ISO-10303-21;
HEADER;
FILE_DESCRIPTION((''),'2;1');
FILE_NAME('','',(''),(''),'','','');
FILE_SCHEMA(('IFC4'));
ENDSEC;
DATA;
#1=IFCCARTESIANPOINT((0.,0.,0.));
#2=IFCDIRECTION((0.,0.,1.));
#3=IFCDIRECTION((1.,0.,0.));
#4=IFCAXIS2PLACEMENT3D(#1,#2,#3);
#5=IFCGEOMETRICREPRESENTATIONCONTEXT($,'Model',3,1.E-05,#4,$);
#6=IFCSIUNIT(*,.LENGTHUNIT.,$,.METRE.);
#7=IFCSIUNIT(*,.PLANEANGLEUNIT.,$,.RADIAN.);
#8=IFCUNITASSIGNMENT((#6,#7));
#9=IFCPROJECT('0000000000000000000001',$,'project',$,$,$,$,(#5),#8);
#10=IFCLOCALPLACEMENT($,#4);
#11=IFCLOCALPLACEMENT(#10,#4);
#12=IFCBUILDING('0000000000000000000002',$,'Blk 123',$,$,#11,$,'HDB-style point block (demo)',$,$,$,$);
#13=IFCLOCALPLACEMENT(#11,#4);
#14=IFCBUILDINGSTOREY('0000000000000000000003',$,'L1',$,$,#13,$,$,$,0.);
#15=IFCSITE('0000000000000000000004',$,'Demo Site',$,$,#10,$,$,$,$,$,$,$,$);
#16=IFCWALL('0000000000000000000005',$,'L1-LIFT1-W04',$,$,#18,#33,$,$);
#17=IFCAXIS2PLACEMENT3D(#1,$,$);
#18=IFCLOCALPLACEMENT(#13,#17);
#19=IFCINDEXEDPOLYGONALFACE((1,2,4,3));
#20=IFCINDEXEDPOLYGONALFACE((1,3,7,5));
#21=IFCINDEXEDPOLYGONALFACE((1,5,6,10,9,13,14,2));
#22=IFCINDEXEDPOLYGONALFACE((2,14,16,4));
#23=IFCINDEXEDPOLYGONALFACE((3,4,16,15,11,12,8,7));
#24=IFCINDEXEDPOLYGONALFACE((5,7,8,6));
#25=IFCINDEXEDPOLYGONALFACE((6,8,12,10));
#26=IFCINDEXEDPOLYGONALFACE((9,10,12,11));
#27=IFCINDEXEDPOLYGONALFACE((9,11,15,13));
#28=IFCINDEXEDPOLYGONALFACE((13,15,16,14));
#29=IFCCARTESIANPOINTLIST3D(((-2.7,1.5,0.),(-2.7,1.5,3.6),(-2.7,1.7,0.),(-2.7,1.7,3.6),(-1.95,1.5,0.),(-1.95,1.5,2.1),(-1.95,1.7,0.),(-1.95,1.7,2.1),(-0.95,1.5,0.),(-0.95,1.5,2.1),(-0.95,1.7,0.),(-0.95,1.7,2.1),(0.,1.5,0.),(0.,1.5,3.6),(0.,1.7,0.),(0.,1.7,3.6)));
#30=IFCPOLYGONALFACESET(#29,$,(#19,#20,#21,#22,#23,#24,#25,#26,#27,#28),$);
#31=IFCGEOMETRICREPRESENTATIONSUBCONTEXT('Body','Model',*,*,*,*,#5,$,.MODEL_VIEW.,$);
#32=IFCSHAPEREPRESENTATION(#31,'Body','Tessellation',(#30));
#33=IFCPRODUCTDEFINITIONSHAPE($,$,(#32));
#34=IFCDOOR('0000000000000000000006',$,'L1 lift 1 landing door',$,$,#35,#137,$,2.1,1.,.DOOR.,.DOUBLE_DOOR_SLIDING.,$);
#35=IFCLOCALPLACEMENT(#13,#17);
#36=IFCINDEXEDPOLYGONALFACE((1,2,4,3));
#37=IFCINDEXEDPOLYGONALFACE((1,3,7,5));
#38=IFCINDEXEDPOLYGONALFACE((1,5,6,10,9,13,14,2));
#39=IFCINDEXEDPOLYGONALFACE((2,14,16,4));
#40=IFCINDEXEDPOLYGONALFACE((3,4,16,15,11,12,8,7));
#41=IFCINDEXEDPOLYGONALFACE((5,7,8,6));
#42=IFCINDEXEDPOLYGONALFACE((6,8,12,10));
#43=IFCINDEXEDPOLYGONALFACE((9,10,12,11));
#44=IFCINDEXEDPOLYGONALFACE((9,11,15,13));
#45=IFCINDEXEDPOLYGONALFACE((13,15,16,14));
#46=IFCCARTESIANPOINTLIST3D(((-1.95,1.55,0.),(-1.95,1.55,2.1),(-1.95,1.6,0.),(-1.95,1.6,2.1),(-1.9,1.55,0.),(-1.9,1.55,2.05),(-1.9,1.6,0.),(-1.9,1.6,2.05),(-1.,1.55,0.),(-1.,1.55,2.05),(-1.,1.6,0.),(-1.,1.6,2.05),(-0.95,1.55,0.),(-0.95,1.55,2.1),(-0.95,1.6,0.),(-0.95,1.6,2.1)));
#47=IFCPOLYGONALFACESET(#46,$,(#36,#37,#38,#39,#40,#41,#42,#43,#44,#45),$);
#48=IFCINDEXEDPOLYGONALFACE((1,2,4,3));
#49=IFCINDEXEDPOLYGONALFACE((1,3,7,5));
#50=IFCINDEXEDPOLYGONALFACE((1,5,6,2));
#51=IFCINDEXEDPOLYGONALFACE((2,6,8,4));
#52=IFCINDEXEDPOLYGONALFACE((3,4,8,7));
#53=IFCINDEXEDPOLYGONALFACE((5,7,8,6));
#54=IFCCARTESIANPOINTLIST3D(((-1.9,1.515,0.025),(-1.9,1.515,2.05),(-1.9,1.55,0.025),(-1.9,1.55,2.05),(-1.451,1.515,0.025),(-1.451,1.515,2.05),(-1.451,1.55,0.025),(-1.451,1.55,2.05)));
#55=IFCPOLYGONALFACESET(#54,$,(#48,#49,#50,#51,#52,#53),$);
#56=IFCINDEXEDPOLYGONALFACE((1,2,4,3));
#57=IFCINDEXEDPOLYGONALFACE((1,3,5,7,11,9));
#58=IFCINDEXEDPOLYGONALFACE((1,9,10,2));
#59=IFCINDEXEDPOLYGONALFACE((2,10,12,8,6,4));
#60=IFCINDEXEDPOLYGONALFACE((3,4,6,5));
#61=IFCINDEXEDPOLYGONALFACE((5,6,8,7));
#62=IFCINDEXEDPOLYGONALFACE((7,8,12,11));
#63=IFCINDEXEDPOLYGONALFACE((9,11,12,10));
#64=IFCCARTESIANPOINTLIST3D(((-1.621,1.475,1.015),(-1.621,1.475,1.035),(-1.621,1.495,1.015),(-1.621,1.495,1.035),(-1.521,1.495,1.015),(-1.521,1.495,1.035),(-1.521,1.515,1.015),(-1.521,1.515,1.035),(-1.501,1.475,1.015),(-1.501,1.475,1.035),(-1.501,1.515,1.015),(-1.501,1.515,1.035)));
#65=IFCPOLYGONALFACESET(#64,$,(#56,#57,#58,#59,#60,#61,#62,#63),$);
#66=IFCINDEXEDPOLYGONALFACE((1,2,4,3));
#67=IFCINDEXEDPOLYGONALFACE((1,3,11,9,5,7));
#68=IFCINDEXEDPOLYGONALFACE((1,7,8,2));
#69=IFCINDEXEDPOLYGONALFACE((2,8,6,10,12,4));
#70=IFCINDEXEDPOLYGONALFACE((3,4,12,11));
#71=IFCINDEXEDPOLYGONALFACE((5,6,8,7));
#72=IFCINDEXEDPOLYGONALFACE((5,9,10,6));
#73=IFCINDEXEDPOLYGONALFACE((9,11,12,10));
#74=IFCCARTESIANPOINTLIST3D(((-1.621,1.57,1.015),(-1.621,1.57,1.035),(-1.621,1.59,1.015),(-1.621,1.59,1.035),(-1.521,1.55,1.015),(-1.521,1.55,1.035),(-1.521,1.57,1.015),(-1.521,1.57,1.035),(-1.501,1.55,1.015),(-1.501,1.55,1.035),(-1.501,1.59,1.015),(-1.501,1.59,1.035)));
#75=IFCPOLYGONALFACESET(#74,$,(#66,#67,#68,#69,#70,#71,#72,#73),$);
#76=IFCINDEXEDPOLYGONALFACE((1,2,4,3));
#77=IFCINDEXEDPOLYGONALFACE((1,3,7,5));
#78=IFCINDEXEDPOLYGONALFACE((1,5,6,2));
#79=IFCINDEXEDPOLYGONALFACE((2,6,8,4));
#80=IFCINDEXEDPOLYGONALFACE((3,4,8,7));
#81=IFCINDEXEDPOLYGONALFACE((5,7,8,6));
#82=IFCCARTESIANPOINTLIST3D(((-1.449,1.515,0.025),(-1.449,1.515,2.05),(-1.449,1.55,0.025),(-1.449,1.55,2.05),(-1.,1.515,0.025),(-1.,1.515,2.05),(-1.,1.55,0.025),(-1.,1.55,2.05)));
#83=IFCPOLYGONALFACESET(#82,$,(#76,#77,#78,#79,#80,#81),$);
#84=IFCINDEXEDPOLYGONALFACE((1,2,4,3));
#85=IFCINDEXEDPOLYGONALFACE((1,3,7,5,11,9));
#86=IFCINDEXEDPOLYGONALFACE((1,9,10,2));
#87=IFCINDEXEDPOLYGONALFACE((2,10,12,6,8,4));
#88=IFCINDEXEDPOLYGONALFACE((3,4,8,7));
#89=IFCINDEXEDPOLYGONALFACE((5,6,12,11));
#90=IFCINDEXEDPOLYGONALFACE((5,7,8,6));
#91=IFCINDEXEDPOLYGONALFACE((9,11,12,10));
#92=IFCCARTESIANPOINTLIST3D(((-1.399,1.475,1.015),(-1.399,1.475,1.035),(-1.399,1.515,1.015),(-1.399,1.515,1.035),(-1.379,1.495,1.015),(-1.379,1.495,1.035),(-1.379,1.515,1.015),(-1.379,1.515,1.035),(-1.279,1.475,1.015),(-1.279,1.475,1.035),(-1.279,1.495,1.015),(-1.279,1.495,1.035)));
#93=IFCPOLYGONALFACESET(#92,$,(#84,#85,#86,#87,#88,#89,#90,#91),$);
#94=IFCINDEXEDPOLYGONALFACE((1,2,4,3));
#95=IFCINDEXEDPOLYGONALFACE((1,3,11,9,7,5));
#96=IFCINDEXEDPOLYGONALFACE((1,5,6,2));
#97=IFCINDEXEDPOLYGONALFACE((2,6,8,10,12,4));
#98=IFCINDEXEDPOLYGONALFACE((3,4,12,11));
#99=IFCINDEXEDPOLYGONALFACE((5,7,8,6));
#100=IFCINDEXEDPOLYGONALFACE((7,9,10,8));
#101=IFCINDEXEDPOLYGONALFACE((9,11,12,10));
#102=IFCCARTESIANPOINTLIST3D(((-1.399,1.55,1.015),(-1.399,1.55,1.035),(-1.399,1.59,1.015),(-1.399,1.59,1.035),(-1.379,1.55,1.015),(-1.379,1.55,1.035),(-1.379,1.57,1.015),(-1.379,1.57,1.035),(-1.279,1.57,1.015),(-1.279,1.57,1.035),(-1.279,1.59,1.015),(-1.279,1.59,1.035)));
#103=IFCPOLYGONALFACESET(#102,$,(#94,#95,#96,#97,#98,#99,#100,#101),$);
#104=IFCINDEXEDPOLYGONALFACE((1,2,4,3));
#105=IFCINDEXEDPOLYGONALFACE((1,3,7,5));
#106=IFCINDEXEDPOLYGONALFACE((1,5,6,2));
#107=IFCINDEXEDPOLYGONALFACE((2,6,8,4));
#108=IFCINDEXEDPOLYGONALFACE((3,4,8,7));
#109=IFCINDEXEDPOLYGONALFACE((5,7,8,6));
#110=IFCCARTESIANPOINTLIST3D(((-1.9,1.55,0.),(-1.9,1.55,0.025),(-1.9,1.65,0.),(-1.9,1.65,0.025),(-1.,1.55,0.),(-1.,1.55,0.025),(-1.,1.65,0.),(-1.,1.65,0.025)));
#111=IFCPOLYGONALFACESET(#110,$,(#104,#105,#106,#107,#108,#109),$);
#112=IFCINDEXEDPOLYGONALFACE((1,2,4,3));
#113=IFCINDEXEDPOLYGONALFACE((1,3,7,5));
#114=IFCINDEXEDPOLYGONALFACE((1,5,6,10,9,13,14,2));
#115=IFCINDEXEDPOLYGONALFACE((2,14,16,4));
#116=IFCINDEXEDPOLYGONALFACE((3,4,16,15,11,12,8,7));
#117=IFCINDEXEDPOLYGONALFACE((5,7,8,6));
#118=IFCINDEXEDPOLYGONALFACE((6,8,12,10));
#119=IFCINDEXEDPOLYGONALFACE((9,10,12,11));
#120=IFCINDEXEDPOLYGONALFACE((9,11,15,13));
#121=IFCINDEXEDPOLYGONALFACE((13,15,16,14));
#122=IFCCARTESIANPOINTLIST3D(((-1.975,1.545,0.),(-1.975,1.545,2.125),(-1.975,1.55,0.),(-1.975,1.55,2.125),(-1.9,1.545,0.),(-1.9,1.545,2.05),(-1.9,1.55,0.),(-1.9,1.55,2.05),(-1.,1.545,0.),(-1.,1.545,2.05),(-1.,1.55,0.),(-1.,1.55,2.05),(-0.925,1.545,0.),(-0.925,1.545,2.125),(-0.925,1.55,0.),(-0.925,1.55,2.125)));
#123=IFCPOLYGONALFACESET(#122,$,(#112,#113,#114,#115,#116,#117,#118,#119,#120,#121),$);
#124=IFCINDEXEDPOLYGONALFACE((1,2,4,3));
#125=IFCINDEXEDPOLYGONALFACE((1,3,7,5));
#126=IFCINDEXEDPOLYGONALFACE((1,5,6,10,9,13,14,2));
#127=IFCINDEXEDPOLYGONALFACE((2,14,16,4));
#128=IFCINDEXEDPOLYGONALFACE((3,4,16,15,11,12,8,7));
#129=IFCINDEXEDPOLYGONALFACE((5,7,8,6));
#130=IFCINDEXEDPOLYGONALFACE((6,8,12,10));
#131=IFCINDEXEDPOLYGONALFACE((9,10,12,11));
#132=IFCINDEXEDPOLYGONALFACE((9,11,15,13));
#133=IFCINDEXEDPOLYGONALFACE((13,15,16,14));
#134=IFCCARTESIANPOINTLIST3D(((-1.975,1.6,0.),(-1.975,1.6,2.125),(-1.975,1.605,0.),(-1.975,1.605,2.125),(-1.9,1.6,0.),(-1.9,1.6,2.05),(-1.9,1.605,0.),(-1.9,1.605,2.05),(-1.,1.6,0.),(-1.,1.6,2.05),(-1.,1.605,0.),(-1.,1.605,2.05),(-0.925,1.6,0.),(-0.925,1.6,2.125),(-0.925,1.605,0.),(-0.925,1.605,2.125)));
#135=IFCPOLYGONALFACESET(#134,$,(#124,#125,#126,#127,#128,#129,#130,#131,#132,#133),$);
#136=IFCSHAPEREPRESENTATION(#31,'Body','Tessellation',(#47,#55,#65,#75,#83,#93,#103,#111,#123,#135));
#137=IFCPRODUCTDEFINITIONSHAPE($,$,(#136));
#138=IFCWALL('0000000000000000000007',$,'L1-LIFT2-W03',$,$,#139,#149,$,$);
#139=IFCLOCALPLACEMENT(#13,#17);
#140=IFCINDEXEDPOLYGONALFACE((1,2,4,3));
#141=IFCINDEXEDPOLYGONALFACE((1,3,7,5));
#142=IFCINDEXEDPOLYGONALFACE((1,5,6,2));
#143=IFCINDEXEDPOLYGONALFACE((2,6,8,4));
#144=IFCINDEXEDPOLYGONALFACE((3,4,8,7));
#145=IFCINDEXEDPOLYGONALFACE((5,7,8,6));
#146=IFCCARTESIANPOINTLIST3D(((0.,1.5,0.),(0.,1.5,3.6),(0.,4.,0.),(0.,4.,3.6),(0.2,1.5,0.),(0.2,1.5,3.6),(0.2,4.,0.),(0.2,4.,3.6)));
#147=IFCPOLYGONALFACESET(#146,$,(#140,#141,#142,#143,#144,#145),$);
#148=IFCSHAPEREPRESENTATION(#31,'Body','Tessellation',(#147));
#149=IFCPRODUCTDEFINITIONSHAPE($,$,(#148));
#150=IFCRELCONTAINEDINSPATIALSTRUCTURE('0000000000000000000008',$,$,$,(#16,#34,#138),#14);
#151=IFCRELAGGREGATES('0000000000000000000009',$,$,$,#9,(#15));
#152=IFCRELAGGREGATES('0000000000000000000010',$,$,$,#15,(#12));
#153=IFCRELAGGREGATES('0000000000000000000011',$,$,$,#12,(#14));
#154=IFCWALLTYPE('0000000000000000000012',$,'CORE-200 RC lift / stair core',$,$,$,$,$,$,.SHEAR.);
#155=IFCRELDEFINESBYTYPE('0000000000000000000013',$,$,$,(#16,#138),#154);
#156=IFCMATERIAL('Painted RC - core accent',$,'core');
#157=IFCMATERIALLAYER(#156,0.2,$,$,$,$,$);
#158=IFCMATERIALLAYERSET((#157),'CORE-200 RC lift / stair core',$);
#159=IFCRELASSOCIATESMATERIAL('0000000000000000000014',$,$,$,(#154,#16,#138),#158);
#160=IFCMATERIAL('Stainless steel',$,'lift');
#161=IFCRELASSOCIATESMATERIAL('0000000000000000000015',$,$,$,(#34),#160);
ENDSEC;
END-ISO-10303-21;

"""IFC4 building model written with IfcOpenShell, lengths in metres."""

from ifc_helpers import new_model, si_unit, frame, origin_with_axes, place, context, subcontext, project, spatial, line, indexed_curve, outline, extrude, material, layer, layer_set, layer_usage, type_object, element, fill, save


model = new_model("IFC4")

# Units and contexts
model_context = context("Model", 3, precision=1e-05, world=origin_with_axes())
body_context = subcontext(model_context, "Body", "Model", "MODEL_VIEW")
ifc_project = project(units=[si_unit("LENGTHUNIT", "METRE"), si_unit("PLANEANGLEUNIT", "RADIAN")], contexts=[model_context])

# Site, building, storey
site_placement = place(None, origin_with_axes())
site = spatial("IfcSite", under=ifc_project, at=site_placement, Name="Demo Site")
building_placement = place(site_placement, origin_with_axes())
building = spatial("IfcBuilding", under=site, at=building_placement, Name="Blk 123", LongName="HDB-style point block (demo)")
storey_placement = place(building_placement, origin_with_axes())
storey = spatial("IfcBuildingStorey", under=building, at=storey_placement, Name="L1", Elevation=0.0)

# Shared definitions
ifc_material_1 = material(Name="Painted RC - core accent", Category="core")
ifc_layer = layer(ifc_material_1, 0.2)
ifc_layer_set = layer_set([ifc_layer], Name="CORE-200 RC lift / stair core")
ifc_layer_usage = layer_usage(ifc_layer_set, "AXIS2", "POSITIVE", 0.0)
wall_type = type_object("IfcWallType", Name="CORE-200 RC lift / stair core", PredefinedType="SHEAR", material=ifc_layer_set)

# Wall, opening, door
wall_1_placement = place(storey_placement, frame((-2.7, 1.5, 0.0), z_axis=(0.0, 0.0, 1.0), x_axis=(1.0, 0.0, 0.0)))
wall_1 = element("IfcWall", 1, at=wall_1_placement, inside=storey, type_object=wall_type, material=ifc_layer_usage, Name="L1-LIFT1-W04", context=body_context, shape_type="SweptSolid", body=[
    extrude(outline(indexed_curve([(0.0, 0.0), (0.0, 0.2), (2.7, 0.2), (2.7, 0.0), (0.0, 0.0)], self_intersect=False)), origin_with_axes(), (0.0, 0.0, 1.0), 3.6),
])
opening_1_placement = place(wall_1_placement, frame((0.75, -0.1, 0.0), z_axis=(0.0, 0.0, 1.0), x_axis=(1.0, 0.0, 0.0)))
opening_1 = element("IfcOpeningElement", 2, at=opening_1_placement, cuts=wall_1, context=body_context, shape_type="SweptSolid", body=[
    extrude(outline(indexed_curve([(0.0, 0.0), (0.0, 0.4), (1.0, 0.4), (1.0, 0.0), (0.0, 0.0)], self_intersect=False)), origin_with_axes(), (0.0, 0.0, 1.0), 2.1),
])
ifc_material_2 = material(Name="Stainless steel", Category="lift")
door_1_placement = place(opening_1_placement, frame((0.0, 0.15, 0.0), z_axis=(0.0, 0.0, 1.0), x_axis=(1.0, 0.0, 0.0)))
door_1 = element("IfcDoor", 3, at=door_1_placement, inside=storey, material=ifc_material_2, Name="L1 lift 1 landing door", OperationType="DOUBLE_DOOR_SLIDING", OverallHeight=2.1, OverallWidth=1.0, PredefinedType="DOOR", context=body_context, shape_type="SweptSolid", body=[
    extrude(outline(indexed_curve([(0.0, 0.0), (0.0, 2.1), (1.0, 2.1), (1.0, 0.0), (0.95, 0.0), (0.95, 2.05), (0.05, 2.05), (0.05, 0.0)], segments=[line(1, 2, 3, 4, 5, 6, 7, 8, 1)])), frame((0.0, 0.0, 0.0), z_axis=(0.0, -1.0, 0.0), x_axis=(1.0, 0.0, 0.0)), (0.0, 0.0, -1.0), 0.05),
    extrude(outline(indexed_curve([(0.0, 0.0), (0.449, 0.0), (0.449, 0.035), (0.0, 0.035)], segments=[line(1, 2, 3, 4, 1)])), frame((0.05, -0.035, 0.025), z_axis=(0.0, 0.0, 1.0), x_axis=(1.0, 0.0, 0.0)), (0.0, 0.0, 1.0), 2.025),
    extrude(outline(indexed_curve([(0.0, 0.0), (0.0, -0.04), (-0.12, -0.04), (-0.12, -0.02), (-0.02, -0.02), (-0.02, 0.0)], segments=[line(1, 2, 3, 4, 5, 6, 1)])), frame((0.449, -0.035, 1.015), z_axis=(0.0, 0.0, 1.0), x_axis=(1.0, 0.0, 0.0)), (0.0, 0.0, 1.0), 0.02),
    extrude(outline(indexed_curve([(0.0, 0.0), (0.0, 0.04), (-0.12, 0.04), (-0.12, 0.02), (-0.02, 0.02), (-0.02, 0.0)], segments=[line(1, 2, 3, 4, 5, 6, 1)])), frame((0.449, 0.0, 1.015), z_axis=(0.0, 0.0, 1.0), x_axis=(1.0, 0.0, 0.0)), (0.0, 0.0, 1.0), 0.02),
    extrude(outline(indexed_curve([(0.0, 0.0), (-0.449, 0.0), (-0.449, 0.035), (0.0, 0.035)], segments=[line(1, 2, 3, 4, 1)])), frame((0.95, -0.035, 0.025), z_axis=(0.0, 0.0, 1.0), x_axis=(1.0, 0.0, 0.0)), (0.0, 0.0, 1.0), 2.025),
    extrude(outline(indexed_curve([(0.0, 0.0), (0.0, -0.04), (0.12, -0.04), (0.12, -0.02), (0.02, -0.02), (0.02, 0.0)], segments=[line(1, 2, 3, 4, 5, 6, 1)])), frame((0.551, -0.035, 1.015), z_axis=(0.0, 0.0, 1.0), x_axis=(1.0, 0.0, 0.0)), (0.0, 0.0, 1.0), 0.02),
    extrude(outline(indexed_curve([(0.0, 0.0), (0.0, 0.04), (0.12, 0.04), (0.12, 0.02), (0.02, 0.02), (0.02, 0.0)], segments=[line(1, 2, 3, 4, 5, 6, 1)])), frame((0.551, 0.0, 1.015), z_axis=(0.0, 0.0, 1.0), x_axis=(1.0, 0.0, 0.0)), (0.0, 0.0, 1.0), 0.02),
    extrude(outline(indexed_curve([(0.0, 0.0), (0.9, 0.0), (0.9, 0.1), (0.0, 0.1)], segments=[line(1, 2, 3, 4, 1)])), frame((0.05, 0.0, 0.0), z_axis=(0.0, 0.0, 1.0), x_axis=(1.0, 0.0, 0.0)), (0.0, 0.0, 1.0), 0.025),
    extrude(outline(indexed_curve([(0.0, 0.0), (0.0, 2.125), (1.05, 2.125), (1.05, 0.0), (0.975, 0.0), (0.975, 2.05), (0.075, 2.05), (0.075, 0.0)], segments=[line(1, 2, 3, 4, 5, 6, 7, 8, 1)])), frame((-0.025, -0.005, 0.0), z_axis=(0.0, -1.0, 0.0), x_axis=(1.0, 0.0, 0.0)), (0.0, 0.0, -1.0), 0.005),
    extrude(outline(indexed_curve([(0.0, 0.0), (0.0, 2.125), (1.05, 2.125), (1.05, 0.0), (0.975, 0.0), (0.975, 2.05), (0.075, 2.05), (0.075, 0.0)], segments=[line(1, 2, 3, 4, 5, 6, 7, 8, 1)])), frame((-0.025, 0.05, 0.0), z_axis=(0.0, -1.0, 0.0), x_axis=(1.0, 0.0, 0.0)), (0.0, 0.0, -1.0), 0.005),
])
fill(opening_1, door_1)

# Wall
wall_2_placement = place(storey_placement, frame((0.0, 4.0, 0.0), z_axis=(0.0, 0.0, 1.0), x_axis=(0.0, -1.0, 0.0)))
element("IfcWall", 4, at=wall_2_placement, inside=storey, type_object=wall_type, material=ifc_layer_usage, Name="L1-LIFT2-W03", context=body_context, shape_type="SweptSolid", body=[
    extrude(outline(indexed_curve([(0.0, 0.0), (0.0, 0.2), (2.5, 0.2), (2.5, 0.0), (0.0, 0.0)], self_intersect=False)), origin_with_axes(), (0.0, 0.0, 1.0), 3.6),
])

save(model, "model.ifc")
